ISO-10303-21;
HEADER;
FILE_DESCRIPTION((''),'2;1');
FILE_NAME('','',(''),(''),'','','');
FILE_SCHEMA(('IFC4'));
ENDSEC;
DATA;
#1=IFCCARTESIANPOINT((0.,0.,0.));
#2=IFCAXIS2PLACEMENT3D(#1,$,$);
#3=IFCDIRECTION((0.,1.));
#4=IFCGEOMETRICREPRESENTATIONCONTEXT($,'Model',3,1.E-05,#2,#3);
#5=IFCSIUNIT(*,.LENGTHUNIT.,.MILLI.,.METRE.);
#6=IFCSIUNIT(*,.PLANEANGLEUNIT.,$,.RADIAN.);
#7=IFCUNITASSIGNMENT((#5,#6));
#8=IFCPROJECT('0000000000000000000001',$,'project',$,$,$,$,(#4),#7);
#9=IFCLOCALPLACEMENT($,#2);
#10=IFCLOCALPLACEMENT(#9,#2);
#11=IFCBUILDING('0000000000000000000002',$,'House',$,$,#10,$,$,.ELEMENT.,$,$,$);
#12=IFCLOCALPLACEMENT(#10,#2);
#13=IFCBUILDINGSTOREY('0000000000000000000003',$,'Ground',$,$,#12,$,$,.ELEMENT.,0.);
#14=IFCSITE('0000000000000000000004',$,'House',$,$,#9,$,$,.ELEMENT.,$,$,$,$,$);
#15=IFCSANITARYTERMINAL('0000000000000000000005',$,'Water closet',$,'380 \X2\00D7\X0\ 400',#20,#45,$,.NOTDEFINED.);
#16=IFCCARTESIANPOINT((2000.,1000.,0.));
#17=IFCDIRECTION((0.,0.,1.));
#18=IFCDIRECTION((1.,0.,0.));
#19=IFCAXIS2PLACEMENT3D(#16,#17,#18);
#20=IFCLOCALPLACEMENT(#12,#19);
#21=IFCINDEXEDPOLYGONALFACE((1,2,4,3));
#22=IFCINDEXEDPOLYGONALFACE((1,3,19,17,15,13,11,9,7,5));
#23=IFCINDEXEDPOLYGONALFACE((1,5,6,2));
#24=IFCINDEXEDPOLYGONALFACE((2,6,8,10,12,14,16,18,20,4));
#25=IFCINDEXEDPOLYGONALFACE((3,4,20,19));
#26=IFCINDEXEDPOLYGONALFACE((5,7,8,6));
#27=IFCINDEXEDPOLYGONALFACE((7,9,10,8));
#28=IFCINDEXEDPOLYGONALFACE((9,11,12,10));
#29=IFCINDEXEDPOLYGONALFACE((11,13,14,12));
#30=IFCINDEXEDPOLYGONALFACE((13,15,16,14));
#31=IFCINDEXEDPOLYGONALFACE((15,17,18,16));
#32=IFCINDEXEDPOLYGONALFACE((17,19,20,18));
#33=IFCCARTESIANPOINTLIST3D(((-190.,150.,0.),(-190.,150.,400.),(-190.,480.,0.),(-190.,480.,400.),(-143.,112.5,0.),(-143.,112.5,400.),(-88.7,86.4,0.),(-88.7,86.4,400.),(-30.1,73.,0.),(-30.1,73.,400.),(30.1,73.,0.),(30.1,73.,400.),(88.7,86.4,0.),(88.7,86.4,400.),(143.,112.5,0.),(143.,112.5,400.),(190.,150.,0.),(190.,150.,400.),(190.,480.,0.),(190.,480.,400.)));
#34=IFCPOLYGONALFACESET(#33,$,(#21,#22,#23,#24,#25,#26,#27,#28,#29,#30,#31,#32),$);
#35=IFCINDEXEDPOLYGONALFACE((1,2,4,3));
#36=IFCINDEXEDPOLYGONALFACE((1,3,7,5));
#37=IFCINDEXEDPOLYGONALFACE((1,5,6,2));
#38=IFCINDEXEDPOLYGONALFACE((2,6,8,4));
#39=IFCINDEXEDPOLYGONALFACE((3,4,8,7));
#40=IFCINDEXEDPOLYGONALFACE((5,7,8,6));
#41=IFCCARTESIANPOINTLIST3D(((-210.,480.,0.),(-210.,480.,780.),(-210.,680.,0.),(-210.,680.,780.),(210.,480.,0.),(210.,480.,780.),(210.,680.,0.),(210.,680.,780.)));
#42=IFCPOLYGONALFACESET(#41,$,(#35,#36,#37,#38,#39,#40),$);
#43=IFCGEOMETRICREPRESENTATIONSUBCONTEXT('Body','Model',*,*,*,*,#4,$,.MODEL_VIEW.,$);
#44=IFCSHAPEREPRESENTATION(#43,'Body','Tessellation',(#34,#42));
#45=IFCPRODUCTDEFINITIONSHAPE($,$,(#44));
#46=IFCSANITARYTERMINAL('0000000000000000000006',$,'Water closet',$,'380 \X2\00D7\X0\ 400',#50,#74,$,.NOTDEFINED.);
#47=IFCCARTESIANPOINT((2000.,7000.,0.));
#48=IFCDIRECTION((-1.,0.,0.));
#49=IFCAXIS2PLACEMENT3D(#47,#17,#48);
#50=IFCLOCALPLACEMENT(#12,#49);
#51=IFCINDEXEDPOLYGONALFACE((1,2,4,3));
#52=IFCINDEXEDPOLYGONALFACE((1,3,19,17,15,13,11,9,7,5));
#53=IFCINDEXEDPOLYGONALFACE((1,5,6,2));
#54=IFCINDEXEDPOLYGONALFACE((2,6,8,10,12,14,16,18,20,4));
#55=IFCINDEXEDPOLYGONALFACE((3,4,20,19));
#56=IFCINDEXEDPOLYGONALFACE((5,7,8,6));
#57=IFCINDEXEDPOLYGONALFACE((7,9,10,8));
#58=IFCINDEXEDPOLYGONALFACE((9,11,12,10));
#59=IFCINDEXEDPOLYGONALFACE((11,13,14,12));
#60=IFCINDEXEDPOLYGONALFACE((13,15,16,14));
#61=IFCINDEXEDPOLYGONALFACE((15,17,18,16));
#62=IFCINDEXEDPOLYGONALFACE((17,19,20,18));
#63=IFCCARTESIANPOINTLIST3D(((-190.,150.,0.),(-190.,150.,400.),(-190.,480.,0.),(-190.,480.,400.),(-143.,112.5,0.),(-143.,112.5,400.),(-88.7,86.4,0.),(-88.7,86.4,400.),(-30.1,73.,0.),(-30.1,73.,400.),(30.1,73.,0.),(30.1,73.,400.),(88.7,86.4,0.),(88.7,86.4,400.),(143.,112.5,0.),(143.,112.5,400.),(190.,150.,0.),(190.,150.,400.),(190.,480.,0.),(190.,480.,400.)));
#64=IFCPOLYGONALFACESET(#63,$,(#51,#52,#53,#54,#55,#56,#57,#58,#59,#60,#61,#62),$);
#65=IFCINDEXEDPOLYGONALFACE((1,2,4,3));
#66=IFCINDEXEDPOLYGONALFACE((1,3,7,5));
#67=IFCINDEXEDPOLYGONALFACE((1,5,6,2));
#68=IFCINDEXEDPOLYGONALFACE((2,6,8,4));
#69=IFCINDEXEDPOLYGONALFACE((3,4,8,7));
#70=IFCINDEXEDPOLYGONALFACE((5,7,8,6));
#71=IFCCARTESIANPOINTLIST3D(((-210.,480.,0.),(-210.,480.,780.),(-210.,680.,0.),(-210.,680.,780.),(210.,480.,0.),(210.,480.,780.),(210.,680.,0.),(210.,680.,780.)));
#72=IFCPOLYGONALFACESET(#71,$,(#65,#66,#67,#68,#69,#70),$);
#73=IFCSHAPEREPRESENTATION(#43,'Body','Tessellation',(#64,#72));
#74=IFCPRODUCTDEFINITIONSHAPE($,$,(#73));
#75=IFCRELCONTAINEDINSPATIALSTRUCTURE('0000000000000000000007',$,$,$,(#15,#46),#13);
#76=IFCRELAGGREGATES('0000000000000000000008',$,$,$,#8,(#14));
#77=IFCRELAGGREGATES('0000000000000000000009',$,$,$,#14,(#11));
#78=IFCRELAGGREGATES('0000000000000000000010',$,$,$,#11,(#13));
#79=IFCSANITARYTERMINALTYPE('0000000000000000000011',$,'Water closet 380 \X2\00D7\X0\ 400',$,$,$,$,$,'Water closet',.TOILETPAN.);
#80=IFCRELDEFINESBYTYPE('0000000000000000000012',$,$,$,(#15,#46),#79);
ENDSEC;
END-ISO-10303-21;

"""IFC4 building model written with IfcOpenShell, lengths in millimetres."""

from ifc_helpers import new_model, si_unit, direction, frame, origin, origin_with_axes, place, context, subcontext, project, spatial, polyline, line, arc, indexed_curve, outline, extrude, source, transform, mapped, type_object, type_shapes, element, save


model = new_model("IFC4")

# Units and contexts
model_context = context("Model", 3, precision=1e-05, world=origin(), true_north=direction((0.0, 1.0)))
body_context = subcontext(model_context, "Body", "Model", "MODEL_VIEW")
ifc_project = project(units=[si_unit("LENGTHUNIT", "METRE", prefix="MILLI"), si_unit("PLANEANGLEUNIT", "RADIAN")], contexts=[model_context])

# Site, building, storey
site_placement = place(None, origin())
site = spatial("IfcSite", under=ifc_project, at=site_placement, Name="House", CompositionType="ELEMENT")
building_placement = place(site_placement, origin())
building = spatial("IfcBuilding", under=site, at=building_placement, Name="House", CompositionType="ELEMENT")
storey_placement = place(building_placement, origin())
storey = spatial("IfcBuildingStorey", under=building, at=storey_placement, Name="Ground", CompositionType="ELEMENT", Elevation=0.0)

# Sanitary terminals
sanitary_terminal_type_1 = type_object("IfcSanitaryTerminalType", Name="Water closet 380 × 400", ElementType="Water closet", PredefinedType="TOILETPAN")
shared_shape_1 = source(origin(), body_context, "Body", "SweptSolid", [
    extrude(outline(indexed_curve([(-190.0, 480.0), (-190.0, 150.0), (0.0, 71.3), (190.0, 150.0), (190.0, 480.0)], segments=[line(1, 2), arc(2, 3, 4), line(4, 5), line(5, 1)], self_intersect=False)), origin_with_axes(), (0.0, 0.0, 1.0), 400.0),
    extrude(outline(polyline([(-210.0, 480.0), (210.0, 480.0), (210.0, 680.0), (-210.0, 680.0), (-210.0, 480.0)])), origin(), (0.0, 0.0, 1.0), 780.0),
])
type_shapes(sanitary_terminal_type_1, [shared_shape_1])
for number, where, z_axis, x_axis, name in (
    (1, (2000.0, 1000.0, 0.0), (0.0, 0.0, 1.0), (1.0, 0.0, 0.0), "Water closet"),
    (2, (2000.0, 7000.0, 0.0), (0.0, 0.0, 1.0), (-1.0, 0.0, 0.0), "Water closet"),
):
    element("IfcSanitaryTerminal", number, at=place(storey_placement, frame(where, z_axis=z_axis, x_axis=x_axis)), inside=storey, type_object=sanitary_terminal_type_1, Name=name, ObjectType="380 × 400", PredefinedType="NOTDEFINED", context=body_context, shape_type="MappedRepresentation", body=[
        mapped(shared_shape_1, transform((0.0, 0.0, 0.0))),
    ])

save(model, "model.ifc")
